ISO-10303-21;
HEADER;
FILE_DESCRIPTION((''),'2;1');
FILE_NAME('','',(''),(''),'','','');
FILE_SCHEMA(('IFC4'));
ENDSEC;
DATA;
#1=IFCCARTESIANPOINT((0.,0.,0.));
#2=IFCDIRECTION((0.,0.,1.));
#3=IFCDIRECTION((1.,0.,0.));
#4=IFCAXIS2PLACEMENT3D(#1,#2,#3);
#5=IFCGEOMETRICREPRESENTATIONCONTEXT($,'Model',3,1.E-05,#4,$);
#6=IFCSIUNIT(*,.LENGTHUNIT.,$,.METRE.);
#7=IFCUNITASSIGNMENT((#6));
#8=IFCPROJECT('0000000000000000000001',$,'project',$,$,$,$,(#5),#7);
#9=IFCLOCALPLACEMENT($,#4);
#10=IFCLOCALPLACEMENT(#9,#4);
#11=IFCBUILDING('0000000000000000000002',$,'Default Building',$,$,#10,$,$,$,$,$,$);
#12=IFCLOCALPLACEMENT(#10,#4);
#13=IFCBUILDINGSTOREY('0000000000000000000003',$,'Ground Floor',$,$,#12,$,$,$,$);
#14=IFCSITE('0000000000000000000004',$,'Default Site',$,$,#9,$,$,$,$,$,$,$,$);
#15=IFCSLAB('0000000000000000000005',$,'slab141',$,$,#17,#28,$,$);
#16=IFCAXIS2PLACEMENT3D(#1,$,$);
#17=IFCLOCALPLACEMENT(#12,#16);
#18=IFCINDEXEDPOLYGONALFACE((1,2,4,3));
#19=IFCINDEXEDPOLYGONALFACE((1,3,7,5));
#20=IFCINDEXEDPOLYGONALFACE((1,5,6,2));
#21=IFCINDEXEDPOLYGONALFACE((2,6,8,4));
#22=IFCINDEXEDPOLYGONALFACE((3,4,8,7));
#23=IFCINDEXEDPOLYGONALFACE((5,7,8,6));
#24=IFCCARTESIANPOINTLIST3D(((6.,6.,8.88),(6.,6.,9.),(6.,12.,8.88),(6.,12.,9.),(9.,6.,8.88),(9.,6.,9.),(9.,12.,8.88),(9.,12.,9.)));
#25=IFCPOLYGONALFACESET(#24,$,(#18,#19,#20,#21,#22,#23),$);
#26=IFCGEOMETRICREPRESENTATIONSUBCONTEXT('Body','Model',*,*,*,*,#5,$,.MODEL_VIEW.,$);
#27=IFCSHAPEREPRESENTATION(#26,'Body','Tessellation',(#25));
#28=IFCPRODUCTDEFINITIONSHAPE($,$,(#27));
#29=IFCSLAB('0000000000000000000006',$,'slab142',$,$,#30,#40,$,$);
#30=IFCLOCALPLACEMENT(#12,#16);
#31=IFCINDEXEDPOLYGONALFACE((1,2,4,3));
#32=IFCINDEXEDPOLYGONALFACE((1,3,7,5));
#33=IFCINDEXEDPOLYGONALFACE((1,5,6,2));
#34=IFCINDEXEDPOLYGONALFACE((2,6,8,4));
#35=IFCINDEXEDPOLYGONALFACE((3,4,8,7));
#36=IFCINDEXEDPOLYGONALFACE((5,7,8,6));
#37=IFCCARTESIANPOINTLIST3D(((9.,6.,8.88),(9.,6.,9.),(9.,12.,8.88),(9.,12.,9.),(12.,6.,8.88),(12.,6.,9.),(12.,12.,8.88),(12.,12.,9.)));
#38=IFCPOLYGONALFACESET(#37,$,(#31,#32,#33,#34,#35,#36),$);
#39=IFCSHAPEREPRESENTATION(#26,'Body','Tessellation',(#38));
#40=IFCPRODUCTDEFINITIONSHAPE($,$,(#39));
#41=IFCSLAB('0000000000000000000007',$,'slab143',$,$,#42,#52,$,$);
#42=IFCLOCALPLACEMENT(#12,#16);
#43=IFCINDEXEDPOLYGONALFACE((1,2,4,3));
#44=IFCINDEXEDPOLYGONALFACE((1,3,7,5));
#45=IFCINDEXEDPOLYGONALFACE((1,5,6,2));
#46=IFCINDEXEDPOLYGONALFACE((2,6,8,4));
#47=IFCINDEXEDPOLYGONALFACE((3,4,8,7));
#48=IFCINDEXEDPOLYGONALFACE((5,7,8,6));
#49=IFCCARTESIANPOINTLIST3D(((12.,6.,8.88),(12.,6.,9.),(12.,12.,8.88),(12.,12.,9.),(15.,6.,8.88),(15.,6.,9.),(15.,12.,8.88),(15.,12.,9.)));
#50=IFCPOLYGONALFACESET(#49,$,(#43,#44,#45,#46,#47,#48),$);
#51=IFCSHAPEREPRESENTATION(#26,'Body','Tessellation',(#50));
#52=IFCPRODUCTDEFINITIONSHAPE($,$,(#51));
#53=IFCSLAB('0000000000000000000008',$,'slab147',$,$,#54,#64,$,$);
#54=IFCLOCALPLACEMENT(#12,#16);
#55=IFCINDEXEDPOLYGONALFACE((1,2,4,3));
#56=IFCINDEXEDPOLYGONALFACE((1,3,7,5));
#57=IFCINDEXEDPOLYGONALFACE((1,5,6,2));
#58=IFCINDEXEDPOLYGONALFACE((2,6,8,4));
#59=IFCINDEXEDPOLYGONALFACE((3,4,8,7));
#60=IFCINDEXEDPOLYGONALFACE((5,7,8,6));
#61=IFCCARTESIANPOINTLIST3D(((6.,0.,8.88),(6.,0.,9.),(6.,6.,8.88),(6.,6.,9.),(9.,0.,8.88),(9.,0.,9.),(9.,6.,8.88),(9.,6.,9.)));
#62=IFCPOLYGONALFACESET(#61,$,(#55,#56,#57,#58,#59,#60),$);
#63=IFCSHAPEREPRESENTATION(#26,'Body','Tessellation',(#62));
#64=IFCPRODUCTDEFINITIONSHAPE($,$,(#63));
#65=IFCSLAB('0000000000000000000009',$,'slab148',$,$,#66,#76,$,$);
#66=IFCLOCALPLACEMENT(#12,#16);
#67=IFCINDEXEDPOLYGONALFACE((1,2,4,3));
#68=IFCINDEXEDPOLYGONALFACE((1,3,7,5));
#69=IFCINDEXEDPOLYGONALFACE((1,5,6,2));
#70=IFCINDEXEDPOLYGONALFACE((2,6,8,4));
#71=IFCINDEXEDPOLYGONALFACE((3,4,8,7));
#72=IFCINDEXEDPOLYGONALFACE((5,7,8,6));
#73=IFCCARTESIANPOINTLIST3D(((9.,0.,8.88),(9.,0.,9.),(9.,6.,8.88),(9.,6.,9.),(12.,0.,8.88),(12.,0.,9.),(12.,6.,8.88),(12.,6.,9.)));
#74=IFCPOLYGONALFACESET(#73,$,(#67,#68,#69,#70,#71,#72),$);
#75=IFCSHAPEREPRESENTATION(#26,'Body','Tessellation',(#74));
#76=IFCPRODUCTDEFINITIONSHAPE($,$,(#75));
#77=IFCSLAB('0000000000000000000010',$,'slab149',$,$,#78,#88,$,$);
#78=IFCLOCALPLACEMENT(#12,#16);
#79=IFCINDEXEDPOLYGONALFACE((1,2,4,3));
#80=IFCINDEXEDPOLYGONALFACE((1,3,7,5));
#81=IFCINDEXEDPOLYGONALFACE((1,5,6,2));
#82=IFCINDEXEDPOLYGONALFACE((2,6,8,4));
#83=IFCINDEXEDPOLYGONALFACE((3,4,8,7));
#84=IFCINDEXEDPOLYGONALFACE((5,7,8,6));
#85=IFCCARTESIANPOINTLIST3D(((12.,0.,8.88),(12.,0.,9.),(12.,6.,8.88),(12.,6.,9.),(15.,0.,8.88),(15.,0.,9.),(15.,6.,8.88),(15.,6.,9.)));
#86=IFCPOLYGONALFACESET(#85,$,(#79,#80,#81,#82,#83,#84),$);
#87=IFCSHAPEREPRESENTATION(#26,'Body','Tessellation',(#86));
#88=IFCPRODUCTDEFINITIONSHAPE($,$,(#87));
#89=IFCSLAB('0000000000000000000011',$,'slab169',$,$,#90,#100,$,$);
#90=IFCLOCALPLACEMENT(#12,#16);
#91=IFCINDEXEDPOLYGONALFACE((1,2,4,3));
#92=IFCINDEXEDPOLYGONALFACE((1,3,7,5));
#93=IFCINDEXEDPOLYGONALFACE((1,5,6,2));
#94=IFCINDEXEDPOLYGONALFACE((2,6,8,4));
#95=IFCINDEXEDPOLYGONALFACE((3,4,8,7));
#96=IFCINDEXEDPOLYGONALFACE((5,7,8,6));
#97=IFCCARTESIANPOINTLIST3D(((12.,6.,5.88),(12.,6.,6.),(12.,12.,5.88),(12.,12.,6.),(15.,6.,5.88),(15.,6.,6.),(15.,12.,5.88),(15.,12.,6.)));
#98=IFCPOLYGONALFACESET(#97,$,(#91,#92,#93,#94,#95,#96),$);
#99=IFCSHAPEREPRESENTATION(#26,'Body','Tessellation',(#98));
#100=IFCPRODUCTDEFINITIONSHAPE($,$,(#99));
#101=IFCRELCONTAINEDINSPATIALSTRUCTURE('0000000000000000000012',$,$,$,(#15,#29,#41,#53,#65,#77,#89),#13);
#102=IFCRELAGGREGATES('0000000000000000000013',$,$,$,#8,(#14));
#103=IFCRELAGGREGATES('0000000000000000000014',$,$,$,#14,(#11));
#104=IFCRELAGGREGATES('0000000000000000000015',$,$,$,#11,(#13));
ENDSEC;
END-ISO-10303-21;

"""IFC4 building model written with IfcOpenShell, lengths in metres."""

from ifc_helpers import new_model, si_unit, frame, origin_with_axes, place, context, subcontext, project, spatial, indexed_curve, outline, extrude, element, save


model = new_model("IFC4")

# Units and contexts
model_context = context("Model", 3, precision=1e-05, world=origin_with_axes())
body_context = subcontext(model_context, "Body", "Model", "MODEL_VIEW")
ifc_project = project(units=[si_unit("LENGTHUNIT", "METRE")], contexts=[model_context])

# Site, building, storey
site_placement = place(None, origin_with_axes())
site = spatial("IfcSite", under=ifc_project, at=site_placement, Name="Default Site")
building_placement = place(site_placement, origin_with_axes())
building = spatial("IfcBuilding", under=site, at=building_placement, Name="Default Building")
storey_placement = place(building_placement, origin_with_axes())
storey = spatial("IfcBuildingStorey", under=building, at=storey_placement, Name="Ground Floor")

# Slabs
for number, where, z_axis, x_axis, name in (
    (1, (6.0, 6.0, 8.88), (0.0, 0.0, 1.0), (1.0, 0.0, 0.0), "slab141"),
    (2, (9.0, 6.0, 8.88), (0.0, 0.0, 1.0), (1.0, 0.0, 0.0), "slab142"),
    (3, (12.0, 6.0, 8.88), (0.0, 0.0, 1.0), (1.0, 0.0, 0.0), "slab143"),
    (4, (6.0, 0.0, 8.88), (0.0, 0.0, 1.0), (1.0, 0.0, 0.0), "slab147"),
    (5, (9.0, 0.0, 8.88), (0.0, 0.0, 1.0), (1.0, 0.0, 0.0), "slab148"),
    (6, (12.0, 0.0, 8.88), (0.0, 0.0, 1.0), (1.0, 0.0, 0.0), "slab149"),
    (7, (12.0, 6.0, 5.88), (0.0, 0.0, 1.0), (1.0, 0.0, 0.0), "slab169"),
):
    element("IfcSlab", number, at=place(storey_placement, frame(where, z_axis=z_axis, x_axis=x_axis)), inside=storey, Name=name, context=body_context, shape_type="SweptSolid", body=[
        extrude(outline(indexed_curve([(0.0, 0.0), (0.0, 6.0), (3.0, 6.0), (3.0, 0.0), (0.0, 0.0)], self_intersect=False)), origin_with_axes(), (0.0, 0.0, 1.0), 0.12),
    ])

save(model, "model.ifc")
